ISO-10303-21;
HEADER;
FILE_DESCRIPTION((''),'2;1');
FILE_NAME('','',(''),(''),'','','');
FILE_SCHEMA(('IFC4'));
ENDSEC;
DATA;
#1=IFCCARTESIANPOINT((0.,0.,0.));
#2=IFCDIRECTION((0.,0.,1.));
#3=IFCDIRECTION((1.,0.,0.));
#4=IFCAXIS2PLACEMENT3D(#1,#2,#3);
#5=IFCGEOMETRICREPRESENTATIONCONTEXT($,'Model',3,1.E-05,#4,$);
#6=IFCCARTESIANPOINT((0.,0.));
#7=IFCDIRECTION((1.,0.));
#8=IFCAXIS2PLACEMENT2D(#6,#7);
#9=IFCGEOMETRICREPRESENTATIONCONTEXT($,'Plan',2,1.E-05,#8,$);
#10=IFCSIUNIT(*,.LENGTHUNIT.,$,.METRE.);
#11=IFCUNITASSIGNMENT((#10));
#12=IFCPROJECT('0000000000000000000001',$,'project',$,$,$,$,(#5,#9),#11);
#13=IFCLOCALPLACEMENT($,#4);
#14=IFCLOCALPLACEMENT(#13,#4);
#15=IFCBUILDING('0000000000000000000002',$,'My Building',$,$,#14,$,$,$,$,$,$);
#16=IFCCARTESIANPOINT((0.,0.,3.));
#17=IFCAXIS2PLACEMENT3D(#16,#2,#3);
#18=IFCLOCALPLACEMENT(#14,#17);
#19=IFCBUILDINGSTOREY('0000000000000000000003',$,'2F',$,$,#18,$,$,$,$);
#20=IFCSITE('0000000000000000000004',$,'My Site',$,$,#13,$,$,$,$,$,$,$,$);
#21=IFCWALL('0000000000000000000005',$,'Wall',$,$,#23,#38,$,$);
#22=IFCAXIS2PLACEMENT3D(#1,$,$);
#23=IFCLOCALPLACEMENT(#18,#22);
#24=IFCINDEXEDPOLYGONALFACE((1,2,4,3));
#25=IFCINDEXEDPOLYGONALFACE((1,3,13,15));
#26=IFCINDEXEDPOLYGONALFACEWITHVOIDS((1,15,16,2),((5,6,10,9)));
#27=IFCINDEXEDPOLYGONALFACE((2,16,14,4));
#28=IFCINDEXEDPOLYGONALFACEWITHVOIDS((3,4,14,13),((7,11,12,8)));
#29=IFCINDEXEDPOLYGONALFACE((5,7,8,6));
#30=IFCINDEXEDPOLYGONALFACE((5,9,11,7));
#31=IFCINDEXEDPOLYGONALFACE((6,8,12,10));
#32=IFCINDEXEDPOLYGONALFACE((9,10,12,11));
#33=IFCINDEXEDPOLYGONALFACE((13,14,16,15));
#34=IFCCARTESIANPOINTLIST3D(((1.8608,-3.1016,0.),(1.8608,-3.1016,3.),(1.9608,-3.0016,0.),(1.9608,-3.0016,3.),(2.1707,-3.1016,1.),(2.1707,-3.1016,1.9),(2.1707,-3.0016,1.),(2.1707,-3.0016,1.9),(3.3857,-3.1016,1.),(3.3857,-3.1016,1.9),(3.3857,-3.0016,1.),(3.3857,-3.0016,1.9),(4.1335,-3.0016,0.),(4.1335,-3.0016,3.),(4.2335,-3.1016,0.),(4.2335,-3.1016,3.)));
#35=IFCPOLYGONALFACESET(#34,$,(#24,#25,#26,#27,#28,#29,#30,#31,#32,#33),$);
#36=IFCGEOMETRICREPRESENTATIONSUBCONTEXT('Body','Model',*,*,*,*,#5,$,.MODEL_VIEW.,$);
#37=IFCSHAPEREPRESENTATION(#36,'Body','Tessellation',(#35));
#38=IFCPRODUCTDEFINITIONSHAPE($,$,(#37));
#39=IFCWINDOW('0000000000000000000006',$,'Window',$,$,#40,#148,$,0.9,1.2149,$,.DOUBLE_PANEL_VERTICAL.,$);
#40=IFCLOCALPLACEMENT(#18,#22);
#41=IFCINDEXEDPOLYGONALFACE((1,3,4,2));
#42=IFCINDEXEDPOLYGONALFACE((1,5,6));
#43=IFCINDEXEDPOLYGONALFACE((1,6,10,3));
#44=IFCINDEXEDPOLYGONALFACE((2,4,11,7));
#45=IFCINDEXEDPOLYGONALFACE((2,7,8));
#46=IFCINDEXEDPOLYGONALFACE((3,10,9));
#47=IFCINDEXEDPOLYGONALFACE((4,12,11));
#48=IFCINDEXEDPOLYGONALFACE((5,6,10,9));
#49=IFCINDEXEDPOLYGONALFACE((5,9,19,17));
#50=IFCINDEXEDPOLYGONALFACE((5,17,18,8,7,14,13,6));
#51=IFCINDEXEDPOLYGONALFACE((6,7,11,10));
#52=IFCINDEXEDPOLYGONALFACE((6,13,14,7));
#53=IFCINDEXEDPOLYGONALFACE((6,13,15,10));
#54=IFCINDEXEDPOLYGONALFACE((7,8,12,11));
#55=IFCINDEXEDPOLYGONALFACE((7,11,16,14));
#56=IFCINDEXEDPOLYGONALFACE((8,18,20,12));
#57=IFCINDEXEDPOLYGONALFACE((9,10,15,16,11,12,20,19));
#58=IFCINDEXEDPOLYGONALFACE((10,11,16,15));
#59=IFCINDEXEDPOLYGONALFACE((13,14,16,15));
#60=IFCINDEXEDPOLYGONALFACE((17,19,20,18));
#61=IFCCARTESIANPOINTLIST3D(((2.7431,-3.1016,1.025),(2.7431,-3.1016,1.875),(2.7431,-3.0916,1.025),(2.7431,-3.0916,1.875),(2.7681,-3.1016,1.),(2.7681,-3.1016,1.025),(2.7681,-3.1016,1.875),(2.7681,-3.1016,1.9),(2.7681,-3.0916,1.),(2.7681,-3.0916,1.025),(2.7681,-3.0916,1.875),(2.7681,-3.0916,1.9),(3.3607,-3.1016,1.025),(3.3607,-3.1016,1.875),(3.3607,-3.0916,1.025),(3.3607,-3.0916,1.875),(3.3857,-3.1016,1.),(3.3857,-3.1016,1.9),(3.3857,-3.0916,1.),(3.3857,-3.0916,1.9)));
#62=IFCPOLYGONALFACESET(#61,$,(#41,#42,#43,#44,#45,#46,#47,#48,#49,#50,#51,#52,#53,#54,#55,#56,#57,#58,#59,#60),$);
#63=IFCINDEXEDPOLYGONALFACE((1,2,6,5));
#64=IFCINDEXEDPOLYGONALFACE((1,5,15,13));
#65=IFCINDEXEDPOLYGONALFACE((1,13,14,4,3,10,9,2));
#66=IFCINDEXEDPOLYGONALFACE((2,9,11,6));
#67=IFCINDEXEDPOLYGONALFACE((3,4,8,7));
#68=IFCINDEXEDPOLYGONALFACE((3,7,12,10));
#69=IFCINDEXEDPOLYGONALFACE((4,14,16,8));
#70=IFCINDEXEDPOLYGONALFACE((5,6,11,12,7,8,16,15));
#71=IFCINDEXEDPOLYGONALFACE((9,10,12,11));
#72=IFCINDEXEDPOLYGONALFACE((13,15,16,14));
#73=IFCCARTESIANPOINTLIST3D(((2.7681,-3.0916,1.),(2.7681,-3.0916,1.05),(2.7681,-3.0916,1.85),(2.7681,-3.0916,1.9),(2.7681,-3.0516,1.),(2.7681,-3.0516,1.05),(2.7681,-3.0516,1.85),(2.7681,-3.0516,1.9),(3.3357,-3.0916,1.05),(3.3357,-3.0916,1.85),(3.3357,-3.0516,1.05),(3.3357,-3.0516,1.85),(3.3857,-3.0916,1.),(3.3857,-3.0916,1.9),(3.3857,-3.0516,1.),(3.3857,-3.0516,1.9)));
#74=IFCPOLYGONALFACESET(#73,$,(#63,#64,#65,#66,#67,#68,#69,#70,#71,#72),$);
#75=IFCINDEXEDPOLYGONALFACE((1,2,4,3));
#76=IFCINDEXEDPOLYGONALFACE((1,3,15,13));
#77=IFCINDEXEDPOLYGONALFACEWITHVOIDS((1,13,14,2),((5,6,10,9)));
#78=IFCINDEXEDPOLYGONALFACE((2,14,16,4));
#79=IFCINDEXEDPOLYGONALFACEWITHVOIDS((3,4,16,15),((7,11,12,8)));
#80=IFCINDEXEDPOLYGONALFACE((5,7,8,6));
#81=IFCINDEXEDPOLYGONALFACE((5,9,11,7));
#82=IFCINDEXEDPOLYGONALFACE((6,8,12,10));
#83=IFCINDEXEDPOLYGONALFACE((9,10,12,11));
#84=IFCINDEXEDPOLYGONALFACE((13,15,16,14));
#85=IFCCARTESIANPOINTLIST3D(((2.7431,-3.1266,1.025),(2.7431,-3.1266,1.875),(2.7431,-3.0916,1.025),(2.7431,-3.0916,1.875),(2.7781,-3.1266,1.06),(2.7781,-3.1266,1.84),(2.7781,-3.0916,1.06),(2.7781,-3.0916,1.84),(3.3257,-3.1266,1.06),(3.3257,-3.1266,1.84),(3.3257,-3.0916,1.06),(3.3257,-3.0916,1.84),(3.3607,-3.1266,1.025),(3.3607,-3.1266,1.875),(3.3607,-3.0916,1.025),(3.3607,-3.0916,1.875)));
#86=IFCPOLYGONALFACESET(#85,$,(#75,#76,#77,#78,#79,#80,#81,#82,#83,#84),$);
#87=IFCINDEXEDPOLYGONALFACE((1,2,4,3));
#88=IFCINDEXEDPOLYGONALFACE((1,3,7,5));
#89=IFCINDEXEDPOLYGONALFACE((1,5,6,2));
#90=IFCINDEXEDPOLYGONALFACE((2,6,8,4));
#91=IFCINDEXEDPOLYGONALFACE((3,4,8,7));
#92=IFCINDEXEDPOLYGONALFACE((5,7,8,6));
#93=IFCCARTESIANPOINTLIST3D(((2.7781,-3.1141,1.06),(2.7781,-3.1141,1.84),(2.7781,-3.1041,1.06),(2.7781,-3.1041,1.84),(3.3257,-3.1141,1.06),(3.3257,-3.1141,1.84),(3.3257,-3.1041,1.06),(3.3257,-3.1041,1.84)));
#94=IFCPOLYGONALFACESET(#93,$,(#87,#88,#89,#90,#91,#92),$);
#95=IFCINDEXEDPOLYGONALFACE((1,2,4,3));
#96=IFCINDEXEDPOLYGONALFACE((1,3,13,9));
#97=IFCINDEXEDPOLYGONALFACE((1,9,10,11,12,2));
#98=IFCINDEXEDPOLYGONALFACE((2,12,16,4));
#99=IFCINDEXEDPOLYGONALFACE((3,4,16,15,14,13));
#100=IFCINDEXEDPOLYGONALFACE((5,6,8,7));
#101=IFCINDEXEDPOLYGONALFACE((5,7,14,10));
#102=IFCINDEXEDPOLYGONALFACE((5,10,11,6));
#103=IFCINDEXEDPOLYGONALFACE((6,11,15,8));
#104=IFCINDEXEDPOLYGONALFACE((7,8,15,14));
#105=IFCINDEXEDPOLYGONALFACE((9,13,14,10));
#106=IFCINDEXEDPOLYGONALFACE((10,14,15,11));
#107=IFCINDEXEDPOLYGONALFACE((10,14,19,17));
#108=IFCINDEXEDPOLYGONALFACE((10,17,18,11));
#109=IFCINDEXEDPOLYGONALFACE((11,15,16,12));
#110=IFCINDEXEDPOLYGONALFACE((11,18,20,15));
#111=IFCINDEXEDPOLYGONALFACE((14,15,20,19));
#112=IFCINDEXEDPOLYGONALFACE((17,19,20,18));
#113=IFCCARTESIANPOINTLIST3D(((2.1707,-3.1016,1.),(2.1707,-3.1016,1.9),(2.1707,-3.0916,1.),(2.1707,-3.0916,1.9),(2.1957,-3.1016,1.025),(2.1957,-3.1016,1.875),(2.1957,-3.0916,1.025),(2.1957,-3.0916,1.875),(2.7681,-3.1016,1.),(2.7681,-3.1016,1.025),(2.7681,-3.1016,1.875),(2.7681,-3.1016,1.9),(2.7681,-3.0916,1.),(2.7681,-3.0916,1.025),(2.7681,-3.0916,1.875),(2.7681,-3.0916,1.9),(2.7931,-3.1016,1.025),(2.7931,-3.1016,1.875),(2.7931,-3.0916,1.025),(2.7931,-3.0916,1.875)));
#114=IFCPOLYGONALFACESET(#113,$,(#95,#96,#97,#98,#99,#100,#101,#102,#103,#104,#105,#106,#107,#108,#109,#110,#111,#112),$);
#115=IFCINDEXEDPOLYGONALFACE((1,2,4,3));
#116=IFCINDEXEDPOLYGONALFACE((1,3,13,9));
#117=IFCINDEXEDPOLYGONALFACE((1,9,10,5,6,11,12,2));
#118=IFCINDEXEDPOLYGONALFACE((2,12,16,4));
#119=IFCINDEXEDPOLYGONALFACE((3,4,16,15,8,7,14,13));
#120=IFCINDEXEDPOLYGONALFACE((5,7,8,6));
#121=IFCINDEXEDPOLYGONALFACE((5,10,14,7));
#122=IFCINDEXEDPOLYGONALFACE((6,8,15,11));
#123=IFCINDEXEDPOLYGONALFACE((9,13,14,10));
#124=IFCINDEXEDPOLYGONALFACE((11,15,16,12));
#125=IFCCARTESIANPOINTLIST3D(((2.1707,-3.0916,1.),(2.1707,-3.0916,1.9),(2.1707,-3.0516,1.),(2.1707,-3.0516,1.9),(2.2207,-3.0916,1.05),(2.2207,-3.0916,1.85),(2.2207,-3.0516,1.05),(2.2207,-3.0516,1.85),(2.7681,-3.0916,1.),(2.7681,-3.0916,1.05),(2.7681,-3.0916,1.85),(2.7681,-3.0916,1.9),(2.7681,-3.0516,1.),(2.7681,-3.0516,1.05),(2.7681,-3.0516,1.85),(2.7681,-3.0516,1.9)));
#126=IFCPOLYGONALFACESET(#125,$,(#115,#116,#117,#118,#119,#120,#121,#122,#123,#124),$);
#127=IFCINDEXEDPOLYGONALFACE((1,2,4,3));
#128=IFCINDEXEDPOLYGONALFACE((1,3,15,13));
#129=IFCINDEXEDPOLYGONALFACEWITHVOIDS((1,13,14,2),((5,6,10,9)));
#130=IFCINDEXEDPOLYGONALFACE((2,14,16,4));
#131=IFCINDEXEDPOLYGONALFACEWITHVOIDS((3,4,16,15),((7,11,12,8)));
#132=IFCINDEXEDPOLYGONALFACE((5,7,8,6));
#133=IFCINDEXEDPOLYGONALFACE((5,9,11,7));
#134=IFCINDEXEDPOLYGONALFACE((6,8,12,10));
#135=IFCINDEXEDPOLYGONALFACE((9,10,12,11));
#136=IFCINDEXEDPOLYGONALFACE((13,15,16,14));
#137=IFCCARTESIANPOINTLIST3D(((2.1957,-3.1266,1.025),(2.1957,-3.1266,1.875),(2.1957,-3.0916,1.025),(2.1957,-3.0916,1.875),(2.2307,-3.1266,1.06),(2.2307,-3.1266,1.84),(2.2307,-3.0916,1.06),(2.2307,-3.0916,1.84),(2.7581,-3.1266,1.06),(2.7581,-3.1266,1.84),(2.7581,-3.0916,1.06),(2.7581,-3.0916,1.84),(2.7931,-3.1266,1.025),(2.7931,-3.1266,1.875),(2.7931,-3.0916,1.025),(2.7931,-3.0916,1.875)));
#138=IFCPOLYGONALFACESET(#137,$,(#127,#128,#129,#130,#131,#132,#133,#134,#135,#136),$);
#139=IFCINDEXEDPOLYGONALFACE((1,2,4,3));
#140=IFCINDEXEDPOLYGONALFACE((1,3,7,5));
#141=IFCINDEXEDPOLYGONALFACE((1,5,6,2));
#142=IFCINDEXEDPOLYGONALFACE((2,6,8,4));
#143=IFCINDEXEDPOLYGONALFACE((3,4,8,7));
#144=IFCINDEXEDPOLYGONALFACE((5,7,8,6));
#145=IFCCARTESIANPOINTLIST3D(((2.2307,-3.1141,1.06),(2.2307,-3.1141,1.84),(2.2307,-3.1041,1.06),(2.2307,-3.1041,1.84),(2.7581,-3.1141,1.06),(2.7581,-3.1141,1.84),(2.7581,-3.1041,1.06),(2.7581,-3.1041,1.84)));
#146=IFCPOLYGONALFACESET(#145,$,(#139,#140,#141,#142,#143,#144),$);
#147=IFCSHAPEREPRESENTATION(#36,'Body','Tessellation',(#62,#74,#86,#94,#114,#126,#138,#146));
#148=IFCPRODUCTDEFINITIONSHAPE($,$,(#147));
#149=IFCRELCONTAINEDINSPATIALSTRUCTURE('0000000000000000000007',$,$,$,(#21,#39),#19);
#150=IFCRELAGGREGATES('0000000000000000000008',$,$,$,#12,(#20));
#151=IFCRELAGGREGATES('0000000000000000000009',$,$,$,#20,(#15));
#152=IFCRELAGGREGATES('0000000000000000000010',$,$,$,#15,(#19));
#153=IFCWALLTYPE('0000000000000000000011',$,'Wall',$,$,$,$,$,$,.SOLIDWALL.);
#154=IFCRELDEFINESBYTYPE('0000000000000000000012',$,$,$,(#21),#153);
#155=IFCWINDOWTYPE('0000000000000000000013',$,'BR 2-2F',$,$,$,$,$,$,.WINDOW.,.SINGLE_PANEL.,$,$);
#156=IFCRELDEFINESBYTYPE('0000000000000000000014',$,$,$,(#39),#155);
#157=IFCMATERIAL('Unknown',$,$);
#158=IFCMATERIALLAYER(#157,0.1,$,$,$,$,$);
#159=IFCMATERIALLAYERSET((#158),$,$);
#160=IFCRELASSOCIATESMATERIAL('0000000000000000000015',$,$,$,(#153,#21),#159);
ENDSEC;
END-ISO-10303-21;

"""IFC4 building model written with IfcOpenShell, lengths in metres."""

from ifc_helpers import new_model, entity, si_unit, frame, origin_with_axes, origin_2d_with_axis, place, context, subcontext, project, spatial, line, indexed_curve, outline, extrude, shape, source, transform, mapped, material, layer, layer_set, layer_usage, type_object, type_shapes, element, fill, save


model = new_model("IFC4")

# Units and contexts
model_context = context("Model", 3, precision=1e-05, world=origin_with_axes())
plan_context = context("Plan", 2, precision=1e-05, world=origin_2d_with_axis())
body_context_1 = subcontext(model_context, "Body", "Model", "MODEL_VIEW")
body_context_2 = subcontext(plan_context, "Body", "Plan", "PLAN_VIEW")
ifc_project = project(units=[si_unit("LENGTHUNIT", "METRE")], contexts=[model_context, plan_context])

# Site, building, storey
site_placement = place(None, origin_with_axes())
site = spatial("IfcSite", under=ifc_project, at=site_placement, Name="My Site")
building_placement = place(site_placement, origin_with_axes())
building = spatial("IfcBuilding", under=site, at=building_placement, Name="My Building")
storey_placement = place(building_placement, frame((0.0, 0.0, 3.0), z_axis=(0.0, 0.0, 1.0), x_axis=(1.0, 0.0, 0.0)))
storey = spatial("IfcBuildingStorey", under=building, at=storey_placement, Name="2F")

# Shared definitions
ifc_material = material(Name="Unknown")

# Shared definitions
ifc_layer_1 = layer(ifc_material, 0.1)
ifc_layer_set_1 = layer_set([ifc_layer_1])
wall_type = type_object("IfcWallType", Name="Wall", PredefinedType="SOLIDWALL", material=ifc_layer_set_1)

# Wall, opening, window
ifc_layer_usage_1 = layer_usage(ifc_layer_set_1, "AXIS2", "POSITIVE", 0.0)
wall_1_placement = place(storey_placement, frame((1.8608, -3.1016, 0.0), z_axis=(0.0, 0.0, 1.0), x_axis=(1.0, 0.0, 0.0)))
wall_1 = element("IfcWall", 1, at=wall_1_placement, inside=storey, type_object=wall_type, material=ifc_layer_usage_1, Name="Wall", context=body_context_1, shape_type="SweptSolid", body=[
    extrude(outline(indexed_curve([(0.0, 0.0), (0.1, 0.1), (2.2727, 0.1), (2.3727, 0.0)], segments=[line(1, 2, 3, 4, 1)])), origin_with_axes(), (0.0, 0.0, 1.0), 3.0),
])
shared_shape_1 = source(origin_with_axes(), body_context_1, "Body", "SweptSolid", [
    extrude(outline(indexed_curve([(0.0, 0.0), (1.2149, 0.0), (1.2149, 0.9), (0.0, 0.9)], segments=[line(1, 2, 3, 4, 1)])), frame((0.0, -0.6, 0.0), z_axis=(0.0, -1.0, 0.0), x_axis=(1.0, 0.0, 0.0)), (0.0, 0.0, -1.0), 1.2),
])
opening_1_placement = place(wall_1_placement, frame((1.5248, 0.1, 1.0), z_axis=(0.0, 0.0, 1.0), x_axis=(-1.0, 0.000001, 0.0)))
opening_1 = element("IfcOpeningElement", 2, at=opening_1_placement, cuts=wall_1, PredefinedType="OPENING", context=body_context_1, shape_type="MappedRepresentation", body=[
    mapped(shared_shape_1, transform((0.0, 0.0, 0.0), x_axis=(1.0, 0.0, 0.0), y_axis=(0.0, 1.0, 0.0), z_axis=(0.0, 0.0, 1.0), scale=1.0)),
])
window_type_1 = type_object("IfcWindowType", Name="BR 2-2F", PartitioningType="SINGLE_PANEL", PredefinedType="WINDOW")
shared_shape_2 = source(origin_with_axes(), body_context_1, "Body", "SweptSolid", [
    extrude(outline(indexed_curve([(0.0, 0.0), (0.6176, 0.0), (0.6176, 0.9), (0.0, 0.9)], segments=[line(1, 2, 3, 4, 1)]), holes=[indexed_curve([(0.025, 0.025), (0.6426, 0.025), (0.6426, 0.875), (0.025, 0.875)], segments=[line(1, 2, 3, 4, 1)])]), frame((0.0, 0.09, 0.0), z_axis=(0.0, -1.0, 0.0), x_axis=(1.0, 0.0, 0.0)), (0.0, 0.0, -1.0), 0.01),
    extrude(outline(indexed_curve([(0.6176, 0.0), (0.0, 0.0), (0.0, 0.9), (0.6176, 0.9), (0.6176, 0.85), (0.05, 0.85), (0.05, 0.05), (0.6176, 0.05)], segments=[line(1, 2, 3, 4, 5, 6, 7, 8, 1)])), frame((0.0, 0.05, 0.0), z_axis=(0.0, -1.0, 0.0), x_axis=(1.0, 0.0, 0.0)), (0.0, 0.0, -1.0), 0.04),
    extrude(outline(indexed_curve([(0.0, 0.0), (0.6176, 0.0), (0.6176, 0.85), (0.0, 0.85)], segments=[line(1, 2, 3, 4, 1)]), holes=[indexed_curve([(0.035, 0.035), (0.5826, 0.035), (0.5826, 0.815), (0.035, 0.815)], segments=[line(1, 2, 3, 4, 1)])]), frame((0.025, 0.09, 0.025), z_axis=(0.0, -1.0, 0.0), x_axis=(1.0, 0.0, 0.0)), (0.0, 0.0, -1.0), 0.035),
    extrude(outline(indexed_curve([(0.035, 0.035), (0.5826, 0.035), (0.5826, 0.815), (0.035, 0.815)], segments=[line(1, 2, 3, 4, 1)])), frame((0.025, 0.1025, 0.025), z_axis=(0.0, -1.0, 0.0), x_axis=(1.0, 0.0, 0.0)), (0.0, 0.0, -1.0), 0.01),
    extrude(outline(indexed_curve([(0.0, 0.0), (0.5973, 0.0), (0.5973, 0.9), (0.0, 0.9)], segments=[line(1, 2, 3, 4, 1)]), holes=[indexed_curve([(-0.025, 0.025), (0.5723, 0.025), (0.5723, 0.875), (-0.025, 0.875)], segments=[line(1, 2, 3, 4, 1)])]), frame((0.6176, 0.09, 0.0), z_axis=(0.0, -1.0, 0.0), x_axis=(1.0, 0.0, 0.0)), (0.0, 0.0, -1.0), 0.01),
    extrude(outline(indexed_curve([(0.0, 0.9), (0.5973, 0.9), (0.5973, 0.0), (0.0, 0.0), (0.0, 0.05), (0.5473, 0.05), (0.5473, 0.85), (0.0, 0.85)], segments=[line(1, 2, 3, 4, 5, 6, 7, 8, 1)])), frame((0.6176, 0.05, 0.0), z_axis=(0.0, -1.0, 0.0), x_axis=(1.0, 0.0, 0.0)), (0.0, 0.0, -1.0), 0.04),
    extrude(outline(indexed_curve([(0.0, 0.0), (0.5973, 0.0), (0.5973, 0.85), (0.0, 0.85)], segments=[line(1, 2, 3, 4, 1)]), holes=[indexed_curve([(0.035, 0.035), (0.5623, 0.035), (0.5623, 0.815), (0.035, 0.815)], segments=[line(1, 2, 3, 4, 1)])]), frame((0.5926, 0.09, 0.025), z_axis=(0.0, -1.0, 0.0), x_axis=(1.0, 0.0, 0.0)), (0.0, 0.0, -1.0), 0.035),
    extrude(outline(indexed_curve([(0.035, 0.035), (0.5623, 0.035), (0.5623, 0.815), (0.035, 0.815)], segments=[line(1, 2, 3, 4, 1)])), frame((0.5926, 0.1025, 0.025), z_axis=(0.0, -1.0, 0.0), x_axis=(1.0, 0.0, 0.0)), (0.0, 0.0, -1.0), 0.01),
])
shared_shape_3 = source(origin_with_axes(), body_context_2, "Body", "Curve2D", [
    entity("IfcIndexedPolyCurve", entity("IfcCartesianPointList2D", [[0.05, 0.05], [0.6176, 0.05]])),
    entity("IfcIndexedPolyCurve", entity("IfcCartesianPointList2D", [[0.0, 0.1], [0.025, 0.1], [0.025, 0.09], [0.05, 0.09], [0.05, 0.05], [0.0, 0.05]]), [entity("IfcLineIndex", [1, 2, 3, 4, 5, 6, 1])]),
    entity("IfcIndexedPolyCurve", entity("IfcCartesianPointList2D", [[0.6176, 0.1], [0.6426, 0.1], [0.6426, 0.09], [0.6176, 0.09], [0.6176, 0.05], [0.6176, 0.05]])),
    entity("IfcIndexedPolyCurve", entity("IfcCartesianPointList2D", [[0.025, 0.09], [0.06, 0.09], [0.06, 0.125], [0.025, 0.125]]), [entity("IfcLineIndex", [1, 2, 3, 4, 1])]),
    entity("IfcIndexedPolyCurve", entity("IfcCartesianPointList2D", [[0.6426, 0.09], [0.6076, 0.09], [0.6076, 0.125], [0.6426, 0.125]]), [entity("IfcLineIndex", [1, 2, 3, 4, 1])]),
    entity("IfcIndexedPolyCurve", entity("IfcCartesianPointList2D", [[0.06, 0.09], [0.6076, 0.09]])),
    entity("IfcIndexedPolyCurve", entity("IfcCartesianPointList2D", [[0.06, 0.125], [0.6076, 0.125]])),
    entity("IfcIndexedPolyCurve", entity("IfcCartesianPointList2D", [[0.06, 0.1075], [0.6076, 0.1075]])),
    entity("IfcIndexedPolyCurve", entity("IfcCartesianPointList2D", [[0.6176, 0.05], [1.1649, 0.05]])),
    entity("IfcIndexedPolyCurve", entity("IfcCartesianPointList2D", [[0.6176, 0.1], [0.5926, 0.1], [0.5926, 0.09], [0.6176, 0.09], [0.6176, 0.05], [0.6176, 0.05]])),
    entity("IfcIndexedPolyCurve", entity("IfcCartesianPointList2D", [[1.2149, 0.1], [1.1899, 0.1], [1.1899, 0.09], [1.1649, 0.09], [1.1649, 0.05], [1.2149, 0.05]]), [entity("IfcLineIndex", [1, 2, 3, 4, 5, 6, 1])]),
    entity("IfcIndexedPolyCurve", entity("IfcCartesianPointList2D", [[0.5926, 0.09], [0.6276, 0.09], [0.6276, 0.125], [0.5926, 0.125]]), [entity("IfcLineIndex", [1, 2, 3, 4, 1])]),
    entity("IfcIndexedPolyCurve", entity("IfcCartesianPointList2D", [[1.1899, 0.09], [1.1549, 0.09], [1.1549, 0.125], [1.1899, 0.125]]), [entity("IfcLineIndex", [1, 2, 3, 4, 1])]),
    entity("IfcIndexedPolyCurve", entity("IfcCartesianPointList2D", [[0.6276, 0.09], [1.1549, 0.09]])),
    entity("IfcIndexedPolyCurve", entity("IfcCartesianPointList2D", [[0.6276, 0.125], [1.1549, 0.125]])),
    entity("IfcIndexedPolyCurve", entity("IfcCartesianPointList2D", [[0.6276, 0.1075], [1.1549, 0.1075]])),
])
type_shapes(window_type_1, [shared_shape_2, shared_shape_3])
window_1_placement = place(opening_1_placement, origin_with_axes())
window_1 = element("IfcWindow", 3, at=window_1_placement, inside=storey, type_object=window_type_1, Name="Window", OverallHeight=0.9, OverallWidth=1.2149, PartitioningType="DOUBLE_PANEL_VERTICAL", shapes=[
    shape(body_context_1, "Body", "MappedRepresentation", [mapped(shared_shape_2, transform((0.0, 0.0, 0.0), x_axis=(1.0, 0.0, 0.0), y_axis=(0.0, 1.0, 0.0), z_axis=(0.0, 0.0, 1.0), scale=1.0))]),
    shape(body_context_2, "Body", "MappedRepresentation", [mapped(shared_shape_3, transform((0.0, 0.0, 0.0), x_axis=(1.0, 0.0, 0.0), y_axis=(0.0, 1.0, 0.0), z_axis=(0.0, 0.0, 1.0), scale=1.0))]),
])
fill(opening_1, window_1)

save(model, "model.ifc")
